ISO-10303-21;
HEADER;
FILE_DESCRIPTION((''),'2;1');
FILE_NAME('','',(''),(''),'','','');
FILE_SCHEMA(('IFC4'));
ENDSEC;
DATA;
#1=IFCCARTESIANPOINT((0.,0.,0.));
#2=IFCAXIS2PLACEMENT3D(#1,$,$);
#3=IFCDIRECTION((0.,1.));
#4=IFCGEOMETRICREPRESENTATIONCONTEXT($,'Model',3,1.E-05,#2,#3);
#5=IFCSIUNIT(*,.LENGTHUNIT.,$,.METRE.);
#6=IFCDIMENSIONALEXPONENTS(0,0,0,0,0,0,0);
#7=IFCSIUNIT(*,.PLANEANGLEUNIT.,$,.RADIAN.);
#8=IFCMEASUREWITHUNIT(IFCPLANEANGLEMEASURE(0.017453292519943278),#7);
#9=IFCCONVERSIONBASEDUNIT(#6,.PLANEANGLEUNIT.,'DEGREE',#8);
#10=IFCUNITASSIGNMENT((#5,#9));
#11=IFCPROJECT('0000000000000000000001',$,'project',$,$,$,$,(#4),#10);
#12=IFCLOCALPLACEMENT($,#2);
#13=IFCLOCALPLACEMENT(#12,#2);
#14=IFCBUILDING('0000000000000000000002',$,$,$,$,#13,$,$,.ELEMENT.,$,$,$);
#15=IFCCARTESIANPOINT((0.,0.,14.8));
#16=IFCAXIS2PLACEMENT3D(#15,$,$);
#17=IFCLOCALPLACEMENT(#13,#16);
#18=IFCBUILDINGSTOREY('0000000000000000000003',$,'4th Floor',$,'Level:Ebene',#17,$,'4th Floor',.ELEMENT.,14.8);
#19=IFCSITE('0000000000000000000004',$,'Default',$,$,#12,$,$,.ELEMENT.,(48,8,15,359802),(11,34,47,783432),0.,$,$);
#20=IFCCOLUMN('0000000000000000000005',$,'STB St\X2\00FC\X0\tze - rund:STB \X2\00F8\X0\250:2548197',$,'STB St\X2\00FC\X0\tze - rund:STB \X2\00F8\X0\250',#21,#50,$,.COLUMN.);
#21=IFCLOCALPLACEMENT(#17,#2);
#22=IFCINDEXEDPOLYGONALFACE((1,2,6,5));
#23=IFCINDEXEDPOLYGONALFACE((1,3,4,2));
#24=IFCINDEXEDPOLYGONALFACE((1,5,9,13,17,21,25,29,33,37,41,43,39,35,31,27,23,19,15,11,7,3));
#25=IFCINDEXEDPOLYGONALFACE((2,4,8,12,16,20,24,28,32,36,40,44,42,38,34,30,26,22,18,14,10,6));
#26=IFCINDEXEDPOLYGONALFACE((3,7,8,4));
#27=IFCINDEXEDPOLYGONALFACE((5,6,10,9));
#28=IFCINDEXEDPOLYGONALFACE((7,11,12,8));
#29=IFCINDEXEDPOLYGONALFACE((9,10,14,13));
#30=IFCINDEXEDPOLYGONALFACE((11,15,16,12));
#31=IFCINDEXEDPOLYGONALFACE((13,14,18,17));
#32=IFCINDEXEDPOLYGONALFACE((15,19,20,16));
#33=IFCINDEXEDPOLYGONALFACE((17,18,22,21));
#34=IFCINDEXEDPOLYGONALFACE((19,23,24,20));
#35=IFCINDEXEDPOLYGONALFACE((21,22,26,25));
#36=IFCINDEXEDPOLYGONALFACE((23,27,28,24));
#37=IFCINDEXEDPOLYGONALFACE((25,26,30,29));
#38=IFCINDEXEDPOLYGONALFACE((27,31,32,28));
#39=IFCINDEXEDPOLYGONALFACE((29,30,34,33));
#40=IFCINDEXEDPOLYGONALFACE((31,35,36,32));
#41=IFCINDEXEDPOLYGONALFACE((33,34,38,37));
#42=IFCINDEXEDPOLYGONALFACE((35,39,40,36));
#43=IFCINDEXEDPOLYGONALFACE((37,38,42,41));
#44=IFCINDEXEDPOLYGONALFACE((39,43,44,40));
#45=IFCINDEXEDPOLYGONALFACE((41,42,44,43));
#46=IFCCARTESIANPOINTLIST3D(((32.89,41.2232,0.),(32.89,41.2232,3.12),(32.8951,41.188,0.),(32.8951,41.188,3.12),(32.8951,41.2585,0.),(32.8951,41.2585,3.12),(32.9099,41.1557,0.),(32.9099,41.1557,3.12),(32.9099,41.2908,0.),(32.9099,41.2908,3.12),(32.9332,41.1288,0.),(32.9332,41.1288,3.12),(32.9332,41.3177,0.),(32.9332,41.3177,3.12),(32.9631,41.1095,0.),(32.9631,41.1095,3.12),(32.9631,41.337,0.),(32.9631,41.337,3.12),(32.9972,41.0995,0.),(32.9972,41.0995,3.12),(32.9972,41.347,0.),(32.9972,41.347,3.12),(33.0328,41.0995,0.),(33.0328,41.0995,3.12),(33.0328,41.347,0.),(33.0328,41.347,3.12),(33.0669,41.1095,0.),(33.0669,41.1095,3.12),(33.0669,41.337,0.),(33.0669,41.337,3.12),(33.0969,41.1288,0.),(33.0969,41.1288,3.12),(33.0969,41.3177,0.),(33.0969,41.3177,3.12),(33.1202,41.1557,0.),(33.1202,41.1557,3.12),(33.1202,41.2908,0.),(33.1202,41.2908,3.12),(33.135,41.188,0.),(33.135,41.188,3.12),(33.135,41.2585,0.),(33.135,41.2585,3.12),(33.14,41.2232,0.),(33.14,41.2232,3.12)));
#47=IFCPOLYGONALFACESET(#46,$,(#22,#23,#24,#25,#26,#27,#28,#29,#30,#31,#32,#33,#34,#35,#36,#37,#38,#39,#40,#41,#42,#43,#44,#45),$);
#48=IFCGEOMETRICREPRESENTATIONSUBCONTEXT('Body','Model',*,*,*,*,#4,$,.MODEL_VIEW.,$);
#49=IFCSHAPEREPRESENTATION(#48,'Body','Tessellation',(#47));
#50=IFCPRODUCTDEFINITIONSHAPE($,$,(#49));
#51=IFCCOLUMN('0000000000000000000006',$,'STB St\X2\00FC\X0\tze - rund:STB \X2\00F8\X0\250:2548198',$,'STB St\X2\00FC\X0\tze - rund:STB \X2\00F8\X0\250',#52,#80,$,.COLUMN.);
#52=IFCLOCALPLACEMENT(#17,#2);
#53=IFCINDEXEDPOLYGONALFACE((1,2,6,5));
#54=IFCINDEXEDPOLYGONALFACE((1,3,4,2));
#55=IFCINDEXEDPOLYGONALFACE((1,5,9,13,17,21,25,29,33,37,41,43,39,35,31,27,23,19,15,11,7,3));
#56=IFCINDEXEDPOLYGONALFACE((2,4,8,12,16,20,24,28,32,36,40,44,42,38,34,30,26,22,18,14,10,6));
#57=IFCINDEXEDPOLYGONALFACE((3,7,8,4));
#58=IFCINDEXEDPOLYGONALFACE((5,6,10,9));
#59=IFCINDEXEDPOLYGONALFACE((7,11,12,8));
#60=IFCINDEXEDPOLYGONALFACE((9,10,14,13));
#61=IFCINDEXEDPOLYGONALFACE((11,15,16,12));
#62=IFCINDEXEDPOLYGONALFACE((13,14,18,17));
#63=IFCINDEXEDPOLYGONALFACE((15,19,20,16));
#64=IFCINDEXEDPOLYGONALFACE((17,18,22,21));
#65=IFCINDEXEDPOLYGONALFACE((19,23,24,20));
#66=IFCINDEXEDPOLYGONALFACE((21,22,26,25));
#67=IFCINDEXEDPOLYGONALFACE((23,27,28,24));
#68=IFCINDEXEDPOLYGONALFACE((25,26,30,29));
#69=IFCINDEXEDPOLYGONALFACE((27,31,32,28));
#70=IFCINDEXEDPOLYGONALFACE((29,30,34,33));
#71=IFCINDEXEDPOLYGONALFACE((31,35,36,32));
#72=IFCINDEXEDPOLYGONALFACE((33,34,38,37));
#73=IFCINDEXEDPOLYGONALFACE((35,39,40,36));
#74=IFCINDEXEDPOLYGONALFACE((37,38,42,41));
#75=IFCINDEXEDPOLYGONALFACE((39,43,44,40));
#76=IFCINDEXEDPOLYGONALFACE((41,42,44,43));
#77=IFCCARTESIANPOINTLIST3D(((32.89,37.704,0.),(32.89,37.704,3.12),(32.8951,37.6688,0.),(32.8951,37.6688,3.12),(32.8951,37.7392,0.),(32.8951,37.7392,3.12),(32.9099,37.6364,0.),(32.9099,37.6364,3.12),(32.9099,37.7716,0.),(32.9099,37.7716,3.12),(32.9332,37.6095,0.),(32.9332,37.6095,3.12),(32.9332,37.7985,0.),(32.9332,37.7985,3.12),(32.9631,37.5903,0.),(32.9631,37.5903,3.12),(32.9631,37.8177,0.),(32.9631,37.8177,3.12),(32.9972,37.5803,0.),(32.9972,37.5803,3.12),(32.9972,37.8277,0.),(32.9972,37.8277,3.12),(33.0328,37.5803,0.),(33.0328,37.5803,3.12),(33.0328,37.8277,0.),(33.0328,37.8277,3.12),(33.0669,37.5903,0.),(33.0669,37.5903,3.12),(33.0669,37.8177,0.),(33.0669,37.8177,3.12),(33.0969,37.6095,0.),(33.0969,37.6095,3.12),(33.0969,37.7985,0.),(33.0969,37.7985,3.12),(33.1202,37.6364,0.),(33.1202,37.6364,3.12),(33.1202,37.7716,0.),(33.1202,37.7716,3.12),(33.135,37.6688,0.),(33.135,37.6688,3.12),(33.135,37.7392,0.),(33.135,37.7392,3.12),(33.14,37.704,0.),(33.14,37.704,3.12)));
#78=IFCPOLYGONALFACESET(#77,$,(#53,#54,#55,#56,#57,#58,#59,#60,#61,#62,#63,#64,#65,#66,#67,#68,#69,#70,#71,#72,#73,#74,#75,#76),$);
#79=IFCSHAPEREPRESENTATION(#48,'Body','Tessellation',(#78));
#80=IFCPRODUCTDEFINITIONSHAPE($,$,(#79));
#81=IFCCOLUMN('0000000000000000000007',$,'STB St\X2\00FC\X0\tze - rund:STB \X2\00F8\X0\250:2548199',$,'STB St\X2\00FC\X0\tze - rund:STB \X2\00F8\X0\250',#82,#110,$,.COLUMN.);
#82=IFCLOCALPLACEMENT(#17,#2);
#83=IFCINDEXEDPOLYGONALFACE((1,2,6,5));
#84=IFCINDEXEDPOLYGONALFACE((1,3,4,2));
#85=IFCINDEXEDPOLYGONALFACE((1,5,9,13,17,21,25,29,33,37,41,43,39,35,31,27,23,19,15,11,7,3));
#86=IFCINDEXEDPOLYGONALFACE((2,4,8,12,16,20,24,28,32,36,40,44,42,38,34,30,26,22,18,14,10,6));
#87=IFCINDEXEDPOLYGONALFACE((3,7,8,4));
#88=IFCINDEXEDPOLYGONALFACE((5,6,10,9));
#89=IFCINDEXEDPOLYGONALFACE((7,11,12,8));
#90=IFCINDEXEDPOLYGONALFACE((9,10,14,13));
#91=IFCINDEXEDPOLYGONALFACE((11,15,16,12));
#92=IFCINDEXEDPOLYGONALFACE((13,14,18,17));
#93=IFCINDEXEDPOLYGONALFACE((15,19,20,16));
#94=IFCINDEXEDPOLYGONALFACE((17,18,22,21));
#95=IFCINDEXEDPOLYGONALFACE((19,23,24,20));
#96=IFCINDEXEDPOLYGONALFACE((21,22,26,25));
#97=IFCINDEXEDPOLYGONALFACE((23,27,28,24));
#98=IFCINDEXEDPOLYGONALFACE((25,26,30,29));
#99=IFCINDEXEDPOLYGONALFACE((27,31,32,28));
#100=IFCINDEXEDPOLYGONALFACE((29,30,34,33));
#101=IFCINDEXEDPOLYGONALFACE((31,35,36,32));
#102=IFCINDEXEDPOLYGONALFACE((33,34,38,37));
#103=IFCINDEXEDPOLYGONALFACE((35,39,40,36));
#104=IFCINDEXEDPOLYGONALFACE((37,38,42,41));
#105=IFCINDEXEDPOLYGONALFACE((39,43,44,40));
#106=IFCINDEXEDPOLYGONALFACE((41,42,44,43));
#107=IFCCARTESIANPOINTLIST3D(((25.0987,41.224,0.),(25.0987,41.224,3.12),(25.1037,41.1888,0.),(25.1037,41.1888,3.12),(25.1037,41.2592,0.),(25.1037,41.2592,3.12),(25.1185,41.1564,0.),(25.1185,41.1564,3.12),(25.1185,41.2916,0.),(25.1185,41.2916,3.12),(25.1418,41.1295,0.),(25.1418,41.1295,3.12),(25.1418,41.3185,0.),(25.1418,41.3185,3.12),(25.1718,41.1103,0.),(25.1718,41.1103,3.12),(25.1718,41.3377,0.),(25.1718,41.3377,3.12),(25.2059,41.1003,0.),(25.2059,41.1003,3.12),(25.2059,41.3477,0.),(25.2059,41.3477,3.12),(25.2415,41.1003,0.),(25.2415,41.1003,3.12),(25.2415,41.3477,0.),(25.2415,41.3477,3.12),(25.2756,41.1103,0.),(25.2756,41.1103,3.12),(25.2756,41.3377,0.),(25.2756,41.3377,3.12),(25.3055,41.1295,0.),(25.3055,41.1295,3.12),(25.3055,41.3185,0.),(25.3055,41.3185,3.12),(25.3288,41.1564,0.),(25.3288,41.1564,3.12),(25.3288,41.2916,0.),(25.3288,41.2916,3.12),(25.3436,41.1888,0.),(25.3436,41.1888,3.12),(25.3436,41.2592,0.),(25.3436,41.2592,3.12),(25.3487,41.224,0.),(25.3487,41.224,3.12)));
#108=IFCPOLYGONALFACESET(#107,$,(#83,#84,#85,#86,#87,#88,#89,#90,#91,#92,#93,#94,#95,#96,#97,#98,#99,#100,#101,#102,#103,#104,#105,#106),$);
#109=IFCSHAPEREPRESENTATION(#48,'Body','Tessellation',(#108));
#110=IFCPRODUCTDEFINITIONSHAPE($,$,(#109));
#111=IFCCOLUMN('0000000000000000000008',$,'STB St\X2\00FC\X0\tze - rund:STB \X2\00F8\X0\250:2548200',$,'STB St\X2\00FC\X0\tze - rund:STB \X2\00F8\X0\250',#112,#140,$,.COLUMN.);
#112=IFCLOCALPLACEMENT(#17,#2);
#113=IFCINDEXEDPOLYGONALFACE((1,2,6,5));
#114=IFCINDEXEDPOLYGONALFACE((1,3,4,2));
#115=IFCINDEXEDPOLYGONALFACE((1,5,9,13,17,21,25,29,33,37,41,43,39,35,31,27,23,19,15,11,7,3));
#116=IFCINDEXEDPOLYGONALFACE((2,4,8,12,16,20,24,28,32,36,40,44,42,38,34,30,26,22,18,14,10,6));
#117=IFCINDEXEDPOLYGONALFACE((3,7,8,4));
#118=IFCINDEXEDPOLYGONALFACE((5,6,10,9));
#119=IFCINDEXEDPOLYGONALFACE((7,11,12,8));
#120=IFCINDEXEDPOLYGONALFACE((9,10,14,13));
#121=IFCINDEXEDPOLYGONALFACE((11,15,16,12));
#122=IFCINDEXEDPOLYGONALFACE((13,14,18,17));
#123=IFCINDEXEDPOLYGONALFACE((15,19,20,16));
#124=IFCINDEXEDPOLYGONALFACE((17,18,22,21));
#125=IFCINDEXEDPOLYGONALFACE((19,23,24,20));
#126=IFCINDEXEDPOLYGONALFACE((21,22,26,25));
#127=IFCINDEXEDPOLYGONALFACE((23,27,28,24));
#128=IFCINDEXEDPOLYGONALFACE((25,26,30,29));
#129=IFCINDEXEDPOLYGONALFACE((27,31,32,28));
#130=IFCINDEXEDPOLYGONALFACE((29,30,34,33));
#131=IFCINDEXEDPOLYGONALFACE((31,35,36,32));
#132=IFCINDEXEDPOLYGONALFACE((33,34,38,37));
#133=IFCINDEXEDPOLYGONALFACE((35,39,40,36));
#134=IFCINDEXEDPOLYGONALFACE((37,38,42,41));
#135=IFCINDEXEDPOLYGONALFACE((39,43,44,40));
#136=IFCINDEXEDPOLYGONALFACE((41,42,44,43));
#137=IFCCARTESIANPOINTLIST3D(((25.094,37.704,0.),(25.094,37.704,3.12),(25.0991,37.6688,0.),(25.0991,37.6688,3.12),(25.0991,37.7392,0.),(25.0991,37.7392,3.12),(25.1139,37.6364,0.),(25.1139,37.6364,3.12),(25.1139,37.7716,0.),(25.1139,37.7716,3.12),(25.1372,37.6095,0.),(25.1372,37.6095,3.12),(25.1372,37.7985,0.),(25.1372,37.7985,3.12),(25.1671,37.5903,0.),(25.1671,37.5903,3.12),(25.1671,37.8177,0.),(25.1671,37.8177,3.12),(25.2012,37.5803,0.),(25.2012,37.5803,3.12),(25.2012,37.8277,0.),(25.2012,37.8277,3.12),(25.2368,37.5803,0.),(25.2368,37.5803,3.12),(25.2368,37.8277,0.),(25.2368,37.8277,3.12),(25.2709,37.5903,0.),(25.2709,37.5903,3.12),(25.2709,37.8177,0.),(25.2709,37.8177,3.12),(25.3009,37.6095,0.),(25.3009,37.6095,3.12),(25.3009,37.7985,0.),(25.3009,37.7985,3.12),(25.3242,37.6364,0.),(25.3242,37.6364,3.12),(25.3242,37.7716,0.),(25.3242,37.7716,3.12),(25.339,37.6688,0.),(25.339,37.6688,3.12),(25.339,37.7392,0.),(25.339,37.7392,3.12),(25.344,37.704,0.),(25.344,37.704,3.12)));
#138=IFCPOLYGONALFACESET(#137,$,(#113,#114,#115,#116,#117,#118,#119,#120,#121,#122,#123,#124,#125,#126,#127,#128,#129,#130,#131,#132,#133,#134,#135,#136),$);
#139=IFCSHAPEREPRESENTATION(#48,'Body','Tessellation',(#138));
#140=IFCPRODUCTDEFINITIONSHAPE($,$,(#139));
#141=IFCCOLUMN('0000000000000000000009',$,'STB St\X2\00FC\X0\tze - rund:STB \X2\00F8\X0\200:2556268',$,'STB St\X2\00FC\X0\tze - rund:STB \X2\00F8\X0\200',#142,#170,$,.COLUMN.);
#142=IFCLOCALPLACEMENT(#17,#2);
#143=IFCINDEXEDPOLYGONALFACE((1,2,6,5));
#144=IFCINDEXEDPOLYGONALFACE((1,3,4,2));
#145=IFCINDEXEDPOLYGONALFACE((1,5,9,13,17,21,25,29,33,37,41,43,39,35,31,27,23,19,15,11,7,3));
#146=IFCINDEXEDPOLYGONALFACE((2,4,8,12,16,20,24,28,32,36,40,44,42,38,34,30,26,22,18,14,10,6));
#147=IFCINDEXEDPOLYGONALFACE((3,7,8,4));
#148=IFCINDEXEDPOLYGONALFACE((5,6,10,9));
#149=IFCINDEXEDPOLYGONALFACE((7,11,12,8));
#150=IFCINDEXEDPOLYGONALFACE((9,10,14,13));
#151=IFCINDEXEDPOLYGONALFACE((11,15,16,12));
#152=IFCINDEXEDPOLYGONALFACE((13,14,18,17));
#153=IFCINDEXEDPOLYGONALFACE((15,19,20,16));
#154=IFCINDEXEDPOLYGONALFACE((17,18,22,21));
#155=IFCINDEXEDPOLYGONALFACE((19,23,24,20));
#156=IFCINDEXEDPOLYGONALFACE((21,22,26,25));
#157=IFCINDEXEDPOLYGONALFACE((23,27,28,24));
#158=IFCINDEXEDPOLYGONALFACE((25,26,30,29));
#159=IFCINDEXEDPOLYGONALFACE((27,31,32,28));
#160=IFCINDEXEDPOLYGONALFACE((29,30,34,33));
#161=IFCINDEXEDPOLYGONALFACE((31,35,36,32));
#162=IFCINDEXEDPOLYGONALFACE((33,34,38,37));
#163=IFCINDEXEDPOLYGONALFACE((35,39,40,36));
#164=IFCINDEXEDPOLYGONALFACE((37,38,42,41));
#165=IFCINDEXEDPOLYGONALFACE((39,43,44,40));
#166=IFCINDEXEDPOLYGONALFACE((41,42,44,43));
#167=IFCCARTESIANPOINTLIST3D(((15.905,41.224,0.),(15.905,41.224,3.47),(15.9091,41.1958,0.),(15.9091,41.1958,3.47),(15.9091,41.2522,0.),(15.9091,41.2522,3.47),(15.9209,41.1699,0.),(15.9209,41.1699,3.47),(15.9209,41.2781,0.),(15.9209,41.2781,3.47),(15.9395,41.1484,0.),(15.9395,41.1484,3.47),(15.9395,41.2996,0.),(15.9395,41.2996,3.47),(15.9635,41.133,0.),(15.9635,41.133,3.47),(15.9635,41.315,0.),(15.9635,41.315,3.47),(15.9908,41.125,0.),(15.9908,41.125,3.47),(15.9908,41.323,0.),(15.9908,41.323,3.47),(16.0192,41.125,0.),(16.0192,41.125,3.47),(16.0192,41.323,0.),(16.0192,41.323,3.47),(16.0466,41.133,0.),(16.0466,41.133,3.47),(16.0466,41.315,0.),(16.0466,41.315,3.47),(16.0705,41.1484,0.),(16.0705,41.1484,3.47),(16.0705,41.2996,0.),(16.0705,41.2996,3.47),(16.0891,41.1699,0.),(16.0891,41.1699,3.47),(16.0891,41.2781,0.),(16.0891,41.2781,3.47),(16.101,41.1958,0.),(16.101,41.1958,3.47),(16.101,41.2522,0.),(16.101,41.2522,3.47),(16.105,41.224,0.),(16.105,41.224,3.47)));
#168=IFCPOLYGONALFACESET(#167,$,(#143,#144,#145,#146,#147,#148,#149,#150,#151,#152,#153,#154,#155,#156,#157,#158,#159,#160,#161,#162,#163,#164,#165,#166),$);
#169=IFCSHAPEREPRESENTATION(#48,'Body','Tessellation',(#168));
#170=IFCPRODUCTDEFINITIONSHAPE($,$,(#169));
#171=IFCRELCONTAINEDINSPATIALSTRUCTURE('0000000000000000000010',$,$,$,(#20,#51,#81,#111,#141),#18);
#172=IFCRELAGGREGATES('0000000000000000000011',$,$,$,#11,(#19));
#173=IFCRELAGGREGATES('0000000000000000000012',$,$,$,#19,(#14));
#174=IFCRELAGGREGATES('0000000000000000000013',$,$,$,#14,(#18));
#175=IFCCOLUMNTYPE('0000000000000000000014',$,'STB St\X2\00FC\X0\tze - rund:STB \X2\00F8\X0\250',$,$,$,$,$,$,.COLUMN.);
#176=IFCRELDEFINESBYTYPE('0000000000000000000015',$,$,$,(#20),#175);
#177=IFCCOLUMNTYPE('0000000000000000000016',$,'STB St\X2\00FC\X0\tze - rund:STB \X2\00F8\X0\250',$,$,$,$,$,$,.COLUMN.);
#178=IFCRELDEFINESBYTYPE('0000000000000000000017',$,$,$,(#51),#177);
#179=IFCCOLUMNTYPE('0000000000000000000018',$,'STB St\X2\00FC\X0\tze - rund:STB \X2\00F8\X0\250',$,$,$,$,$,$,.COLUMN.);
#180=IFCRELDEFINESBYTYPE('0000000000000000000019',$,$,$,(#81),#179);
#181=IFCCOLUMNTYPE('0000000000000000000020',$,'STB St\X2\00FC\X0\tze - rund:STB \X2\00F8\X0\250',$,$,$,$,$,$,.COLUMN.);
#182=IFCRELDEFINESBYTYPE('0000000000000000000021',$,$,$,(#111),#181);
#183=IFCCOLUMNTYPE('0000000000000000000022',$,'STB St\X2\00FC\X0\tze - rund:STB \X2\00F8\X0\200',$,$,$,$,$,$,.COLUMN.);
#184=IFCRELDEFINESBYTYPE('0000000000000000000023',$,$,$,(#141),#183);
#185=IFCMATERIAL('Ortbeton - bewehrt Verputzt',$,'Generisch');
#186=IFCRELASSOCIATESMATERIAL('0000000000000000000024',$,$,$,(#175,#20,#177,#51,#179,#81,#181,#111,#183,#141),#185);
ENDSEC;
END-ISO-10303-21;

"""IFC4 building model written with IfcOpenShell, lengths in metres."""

from ifc_helpers import new_model, entity, si_unit, converted_unit, direction, frame, origin, place, context, subcontext, project, spatial, arc, indexed_curve, outline, extrude, source, transform, mapped, material, type_object, type_shapes, element, save


model = new_model("IFC4")

# Units and contexts
model_context = context("Model", 3, precision=1e-05, world=origin(), true_north=direction((0.0, 1.0)))
body_context = subcontext(model_context, "Body", "Model", "MODEL_VIEW")
ifc_project = project(units=[si_unit("LENGTHUNIT", "METRE"), converted_unit("PLANEANGLEUNIT", "DEGREE", entity("IfcPlaneAngleMeasure", 0.017453292519943278), si_unit("PLANEANGLEUNIT", "RADIAN"), dimensions=[0, 0, 0, 0, 0, 0, 0])], contexts=[model_context])

# Site, building, storey
site_placement = place(None, origin())
site = spatial("IfcSite", under=ifc_project, at=site_placement, Name="Default", CompositionType="ELEMENT", RefLatitude=(48, 8, 15, 359802), RefLongitude=(11, 34, 47, 783432), RefElevation=0.0)
building_placement = place(site_placement, origin())
building = spatial("IfcBuilding", under=site, at=building_placement, CompositionType="ELEMENT")
storey_placement = place(building_placement, frame((0.0, 0.0, 14.8)))
storey = spatial("IfcBuildingStorey", under=building, at=storey_placement, Name="4th Floor", ObjectType="Level:Ebene", LongName="4th Floor", CompositionType="ELEMENT", Elevation=14.8)

# Columns
ifc_material_1 = material(Name="Ortbeton - bewehrt Verputzt", Category="Generisch")
column_type_1 = type_object("IfcColumnType", Name="STB Stütze - rund:STB ø250", PredefinedType="COLUMN", material=ifc_material_1)
shared_shape_1 = source(origin(), body_context, "Body", "SweptSolid", [
    extrude(outline(indexed_curve([(-0.125, 0.0), (0.0, -0.125), (0.125, 0.0), (0.0, 0.125)], segments=[arc(1, 2, 3), arc(3, 4, 1)], self_intersect=False)), frame((33.015, 41.2232, 14.8)), (0.0, 0.0, 1.0), 3.12),
])
type_shapes(column_type_1, [shared_shape_1])
column_1_placement = place(storey_placement, frame((0.0, 0.0, -14.8)))
element("IfcColumn", 1, at=column_1_placement, inside=storey, type_object=column_type_1, material=ifc_material_1, Name="STB Stütze - rund:STB ø250:2548197", ObjectType="STB Stütze - rund:STB ø250", PredefinedType="COLUMN", context=body_context, shape_type="MappedRepresentation", body=[
    mapped(shared_shape_1, transform((0.0, 0.0, 0.0), scale=1.0)),
])
column_type_2 = type_object("IfcColumnType", Name="STB Stütze - rund:STB ø250", PredefinedType="COLUMN", material=ifc_material_1)
shared_shape_2 = source(origin(), body_context, "Body", "SweptSolid", [
    extrude(outline(indexed_curve([(-0.125, 0.0), (0.0, -0.125), (0.125, 0.0), (0.0, 0.125)], segments=[arc(1, 2, 3), arc(3, 4, 1)], self_intersect=False)), frame((33.015, 37.704, 14.8)), (0.0, 0.0, 1.0), 3.12),
])
type_shapes(column_type_2, [shared_shape_2])
column_2_placement = place(storey_placement, frame((0.0, 0.0, -14.8)))
element("IfcColumn", 2, at=column_2_placement, inside=storey, type_object=column_type_2, material=ifc_material_1, Name="STB Stütze - rund:STB ø250:2548198", ObjectType="STB Stütze - rund:STB ø250", PredefinedType="COLUMN", context=body_context, shape_type="MappedRepresentation", body=[
    mapped(shared_shape_2, transform((0.0, 0.0, 0.0), scale=1.0)),
])
column_type_3 = type_object("IfcColumnType", Name="STB Stütze - rund:STB ø250", PredefinedType="COLUMN", material=ifc_material_1)
shared_shape_3 = source(origin(), body_context, "Body", "SweptSolid", [
    extrude(outline(indexed_curve([(-0.125, 0.0), (0.0, -0.125), (0.125, 0.0), (0.0, 0.125)], segments=[arc(1, 2, 3), arc(3, 4, 1)], self_intersect=False)), frame((25.2237, 41.224, 14.8)), (0.0, 0.0, 1.0), 3.12),
])
type_shapes(column_type_3, [shared_shape_3])
column_3_placement = place(storey_placement, frame((0.0, 0.0, -14.8)))
element("IfcColumn", 3, at=column_3_placement, inside=storey, type_object=column_type_3, material=ifc_material_1, Name="STB Stütze - rund:STB ø250:2548199", ObjectType="STB Stütze - rund:STB ø250", PredefinedType="COLUMN", context=body_context, shape_type="MappedRepresentation", body=[
    mapped(shared_shape_3, transform((0.0, 0.0, 0.0), scale=1.0)),
])
column_type_4 = type_object("IfcColumnType", Name="STB Stütze - rund:STB ø250", PredefinedType="COLUMN", material=ifc_material_1)
shared_shape_4 = source(origin(), body_context, "Body", "SweptSolid", [
    extrude(outline(indexed_curve([(-0.125, 0.0), (0.0, -0.125), (0.125, 0.0), (0.0, 0.125)], segments=[arc(1, 2, 3), arc(3, 4, 1)], self_intersect=False)), frame((25.219, 37.704, 14.8)), (0.0, 0.0, 1.0), 3.12),
])
type_shapes(column_type_4, [shared_shape_4])
column_4_placement = place(storey_placement, frame((0.0, 0.0, -14.8)))
element("IfcColumn", 4, at=column_4_placement, inside=storey, type_object=column_type_4, material=ifc_material_1, Name="STB Stütze - rund:STB ø250:2548200", ObjectType="STB Stütze - rund:STB ø250", PredefinedType="COLUMN", context=body_context, shape_type="MappedRepresentation", body=[
    mapped(shared_shape_4, transform((0.0, 0.0, 0.0), scale=1.0)),
])
column_type_5 = type_object("IfcColumnType", Name="STB Stütze - rund:STB ø200", PredefinedType="COLUMN", material=ifc_material_1)
shared_shape_5 = source(origin(), body_context, "Body", "SweptSolid", [
    extrude(outline(indexed_curve([(-0.1, 0.0), (0.0, -0.1), (0.1, 0.0), (0.0, 0.1)], segments=[arc(1, 2, 3), arc(3, 4, 1)], self_intersect=False)), frame((0.0, 0.0, 14.8)), (0.0, 0.0, 1.0), 3.47),
])
type_shapes(column_type_5, [shared_shape_5])
for number, where, name in (
    (5, (16.005, 41.224, -14.8), "STB Stütze - rund:STB ø200:2556268"),
):
    element("IfcColumn", number, at=place(storey_placement, frame(where)), inside=storey, type_object=column_type_5, material=ifc_material_1, Name=name, ObjectType="STB Stütze - rund:STB ø200", PredefinedType="COLUMN", context=body_context, shape_type="MappedRepresentation", body=[
        mapped(shared_shape_5, transform((0.0, 0.0, 0.0), scale=1.0)),
    ])

save(model, "model.ifc")
